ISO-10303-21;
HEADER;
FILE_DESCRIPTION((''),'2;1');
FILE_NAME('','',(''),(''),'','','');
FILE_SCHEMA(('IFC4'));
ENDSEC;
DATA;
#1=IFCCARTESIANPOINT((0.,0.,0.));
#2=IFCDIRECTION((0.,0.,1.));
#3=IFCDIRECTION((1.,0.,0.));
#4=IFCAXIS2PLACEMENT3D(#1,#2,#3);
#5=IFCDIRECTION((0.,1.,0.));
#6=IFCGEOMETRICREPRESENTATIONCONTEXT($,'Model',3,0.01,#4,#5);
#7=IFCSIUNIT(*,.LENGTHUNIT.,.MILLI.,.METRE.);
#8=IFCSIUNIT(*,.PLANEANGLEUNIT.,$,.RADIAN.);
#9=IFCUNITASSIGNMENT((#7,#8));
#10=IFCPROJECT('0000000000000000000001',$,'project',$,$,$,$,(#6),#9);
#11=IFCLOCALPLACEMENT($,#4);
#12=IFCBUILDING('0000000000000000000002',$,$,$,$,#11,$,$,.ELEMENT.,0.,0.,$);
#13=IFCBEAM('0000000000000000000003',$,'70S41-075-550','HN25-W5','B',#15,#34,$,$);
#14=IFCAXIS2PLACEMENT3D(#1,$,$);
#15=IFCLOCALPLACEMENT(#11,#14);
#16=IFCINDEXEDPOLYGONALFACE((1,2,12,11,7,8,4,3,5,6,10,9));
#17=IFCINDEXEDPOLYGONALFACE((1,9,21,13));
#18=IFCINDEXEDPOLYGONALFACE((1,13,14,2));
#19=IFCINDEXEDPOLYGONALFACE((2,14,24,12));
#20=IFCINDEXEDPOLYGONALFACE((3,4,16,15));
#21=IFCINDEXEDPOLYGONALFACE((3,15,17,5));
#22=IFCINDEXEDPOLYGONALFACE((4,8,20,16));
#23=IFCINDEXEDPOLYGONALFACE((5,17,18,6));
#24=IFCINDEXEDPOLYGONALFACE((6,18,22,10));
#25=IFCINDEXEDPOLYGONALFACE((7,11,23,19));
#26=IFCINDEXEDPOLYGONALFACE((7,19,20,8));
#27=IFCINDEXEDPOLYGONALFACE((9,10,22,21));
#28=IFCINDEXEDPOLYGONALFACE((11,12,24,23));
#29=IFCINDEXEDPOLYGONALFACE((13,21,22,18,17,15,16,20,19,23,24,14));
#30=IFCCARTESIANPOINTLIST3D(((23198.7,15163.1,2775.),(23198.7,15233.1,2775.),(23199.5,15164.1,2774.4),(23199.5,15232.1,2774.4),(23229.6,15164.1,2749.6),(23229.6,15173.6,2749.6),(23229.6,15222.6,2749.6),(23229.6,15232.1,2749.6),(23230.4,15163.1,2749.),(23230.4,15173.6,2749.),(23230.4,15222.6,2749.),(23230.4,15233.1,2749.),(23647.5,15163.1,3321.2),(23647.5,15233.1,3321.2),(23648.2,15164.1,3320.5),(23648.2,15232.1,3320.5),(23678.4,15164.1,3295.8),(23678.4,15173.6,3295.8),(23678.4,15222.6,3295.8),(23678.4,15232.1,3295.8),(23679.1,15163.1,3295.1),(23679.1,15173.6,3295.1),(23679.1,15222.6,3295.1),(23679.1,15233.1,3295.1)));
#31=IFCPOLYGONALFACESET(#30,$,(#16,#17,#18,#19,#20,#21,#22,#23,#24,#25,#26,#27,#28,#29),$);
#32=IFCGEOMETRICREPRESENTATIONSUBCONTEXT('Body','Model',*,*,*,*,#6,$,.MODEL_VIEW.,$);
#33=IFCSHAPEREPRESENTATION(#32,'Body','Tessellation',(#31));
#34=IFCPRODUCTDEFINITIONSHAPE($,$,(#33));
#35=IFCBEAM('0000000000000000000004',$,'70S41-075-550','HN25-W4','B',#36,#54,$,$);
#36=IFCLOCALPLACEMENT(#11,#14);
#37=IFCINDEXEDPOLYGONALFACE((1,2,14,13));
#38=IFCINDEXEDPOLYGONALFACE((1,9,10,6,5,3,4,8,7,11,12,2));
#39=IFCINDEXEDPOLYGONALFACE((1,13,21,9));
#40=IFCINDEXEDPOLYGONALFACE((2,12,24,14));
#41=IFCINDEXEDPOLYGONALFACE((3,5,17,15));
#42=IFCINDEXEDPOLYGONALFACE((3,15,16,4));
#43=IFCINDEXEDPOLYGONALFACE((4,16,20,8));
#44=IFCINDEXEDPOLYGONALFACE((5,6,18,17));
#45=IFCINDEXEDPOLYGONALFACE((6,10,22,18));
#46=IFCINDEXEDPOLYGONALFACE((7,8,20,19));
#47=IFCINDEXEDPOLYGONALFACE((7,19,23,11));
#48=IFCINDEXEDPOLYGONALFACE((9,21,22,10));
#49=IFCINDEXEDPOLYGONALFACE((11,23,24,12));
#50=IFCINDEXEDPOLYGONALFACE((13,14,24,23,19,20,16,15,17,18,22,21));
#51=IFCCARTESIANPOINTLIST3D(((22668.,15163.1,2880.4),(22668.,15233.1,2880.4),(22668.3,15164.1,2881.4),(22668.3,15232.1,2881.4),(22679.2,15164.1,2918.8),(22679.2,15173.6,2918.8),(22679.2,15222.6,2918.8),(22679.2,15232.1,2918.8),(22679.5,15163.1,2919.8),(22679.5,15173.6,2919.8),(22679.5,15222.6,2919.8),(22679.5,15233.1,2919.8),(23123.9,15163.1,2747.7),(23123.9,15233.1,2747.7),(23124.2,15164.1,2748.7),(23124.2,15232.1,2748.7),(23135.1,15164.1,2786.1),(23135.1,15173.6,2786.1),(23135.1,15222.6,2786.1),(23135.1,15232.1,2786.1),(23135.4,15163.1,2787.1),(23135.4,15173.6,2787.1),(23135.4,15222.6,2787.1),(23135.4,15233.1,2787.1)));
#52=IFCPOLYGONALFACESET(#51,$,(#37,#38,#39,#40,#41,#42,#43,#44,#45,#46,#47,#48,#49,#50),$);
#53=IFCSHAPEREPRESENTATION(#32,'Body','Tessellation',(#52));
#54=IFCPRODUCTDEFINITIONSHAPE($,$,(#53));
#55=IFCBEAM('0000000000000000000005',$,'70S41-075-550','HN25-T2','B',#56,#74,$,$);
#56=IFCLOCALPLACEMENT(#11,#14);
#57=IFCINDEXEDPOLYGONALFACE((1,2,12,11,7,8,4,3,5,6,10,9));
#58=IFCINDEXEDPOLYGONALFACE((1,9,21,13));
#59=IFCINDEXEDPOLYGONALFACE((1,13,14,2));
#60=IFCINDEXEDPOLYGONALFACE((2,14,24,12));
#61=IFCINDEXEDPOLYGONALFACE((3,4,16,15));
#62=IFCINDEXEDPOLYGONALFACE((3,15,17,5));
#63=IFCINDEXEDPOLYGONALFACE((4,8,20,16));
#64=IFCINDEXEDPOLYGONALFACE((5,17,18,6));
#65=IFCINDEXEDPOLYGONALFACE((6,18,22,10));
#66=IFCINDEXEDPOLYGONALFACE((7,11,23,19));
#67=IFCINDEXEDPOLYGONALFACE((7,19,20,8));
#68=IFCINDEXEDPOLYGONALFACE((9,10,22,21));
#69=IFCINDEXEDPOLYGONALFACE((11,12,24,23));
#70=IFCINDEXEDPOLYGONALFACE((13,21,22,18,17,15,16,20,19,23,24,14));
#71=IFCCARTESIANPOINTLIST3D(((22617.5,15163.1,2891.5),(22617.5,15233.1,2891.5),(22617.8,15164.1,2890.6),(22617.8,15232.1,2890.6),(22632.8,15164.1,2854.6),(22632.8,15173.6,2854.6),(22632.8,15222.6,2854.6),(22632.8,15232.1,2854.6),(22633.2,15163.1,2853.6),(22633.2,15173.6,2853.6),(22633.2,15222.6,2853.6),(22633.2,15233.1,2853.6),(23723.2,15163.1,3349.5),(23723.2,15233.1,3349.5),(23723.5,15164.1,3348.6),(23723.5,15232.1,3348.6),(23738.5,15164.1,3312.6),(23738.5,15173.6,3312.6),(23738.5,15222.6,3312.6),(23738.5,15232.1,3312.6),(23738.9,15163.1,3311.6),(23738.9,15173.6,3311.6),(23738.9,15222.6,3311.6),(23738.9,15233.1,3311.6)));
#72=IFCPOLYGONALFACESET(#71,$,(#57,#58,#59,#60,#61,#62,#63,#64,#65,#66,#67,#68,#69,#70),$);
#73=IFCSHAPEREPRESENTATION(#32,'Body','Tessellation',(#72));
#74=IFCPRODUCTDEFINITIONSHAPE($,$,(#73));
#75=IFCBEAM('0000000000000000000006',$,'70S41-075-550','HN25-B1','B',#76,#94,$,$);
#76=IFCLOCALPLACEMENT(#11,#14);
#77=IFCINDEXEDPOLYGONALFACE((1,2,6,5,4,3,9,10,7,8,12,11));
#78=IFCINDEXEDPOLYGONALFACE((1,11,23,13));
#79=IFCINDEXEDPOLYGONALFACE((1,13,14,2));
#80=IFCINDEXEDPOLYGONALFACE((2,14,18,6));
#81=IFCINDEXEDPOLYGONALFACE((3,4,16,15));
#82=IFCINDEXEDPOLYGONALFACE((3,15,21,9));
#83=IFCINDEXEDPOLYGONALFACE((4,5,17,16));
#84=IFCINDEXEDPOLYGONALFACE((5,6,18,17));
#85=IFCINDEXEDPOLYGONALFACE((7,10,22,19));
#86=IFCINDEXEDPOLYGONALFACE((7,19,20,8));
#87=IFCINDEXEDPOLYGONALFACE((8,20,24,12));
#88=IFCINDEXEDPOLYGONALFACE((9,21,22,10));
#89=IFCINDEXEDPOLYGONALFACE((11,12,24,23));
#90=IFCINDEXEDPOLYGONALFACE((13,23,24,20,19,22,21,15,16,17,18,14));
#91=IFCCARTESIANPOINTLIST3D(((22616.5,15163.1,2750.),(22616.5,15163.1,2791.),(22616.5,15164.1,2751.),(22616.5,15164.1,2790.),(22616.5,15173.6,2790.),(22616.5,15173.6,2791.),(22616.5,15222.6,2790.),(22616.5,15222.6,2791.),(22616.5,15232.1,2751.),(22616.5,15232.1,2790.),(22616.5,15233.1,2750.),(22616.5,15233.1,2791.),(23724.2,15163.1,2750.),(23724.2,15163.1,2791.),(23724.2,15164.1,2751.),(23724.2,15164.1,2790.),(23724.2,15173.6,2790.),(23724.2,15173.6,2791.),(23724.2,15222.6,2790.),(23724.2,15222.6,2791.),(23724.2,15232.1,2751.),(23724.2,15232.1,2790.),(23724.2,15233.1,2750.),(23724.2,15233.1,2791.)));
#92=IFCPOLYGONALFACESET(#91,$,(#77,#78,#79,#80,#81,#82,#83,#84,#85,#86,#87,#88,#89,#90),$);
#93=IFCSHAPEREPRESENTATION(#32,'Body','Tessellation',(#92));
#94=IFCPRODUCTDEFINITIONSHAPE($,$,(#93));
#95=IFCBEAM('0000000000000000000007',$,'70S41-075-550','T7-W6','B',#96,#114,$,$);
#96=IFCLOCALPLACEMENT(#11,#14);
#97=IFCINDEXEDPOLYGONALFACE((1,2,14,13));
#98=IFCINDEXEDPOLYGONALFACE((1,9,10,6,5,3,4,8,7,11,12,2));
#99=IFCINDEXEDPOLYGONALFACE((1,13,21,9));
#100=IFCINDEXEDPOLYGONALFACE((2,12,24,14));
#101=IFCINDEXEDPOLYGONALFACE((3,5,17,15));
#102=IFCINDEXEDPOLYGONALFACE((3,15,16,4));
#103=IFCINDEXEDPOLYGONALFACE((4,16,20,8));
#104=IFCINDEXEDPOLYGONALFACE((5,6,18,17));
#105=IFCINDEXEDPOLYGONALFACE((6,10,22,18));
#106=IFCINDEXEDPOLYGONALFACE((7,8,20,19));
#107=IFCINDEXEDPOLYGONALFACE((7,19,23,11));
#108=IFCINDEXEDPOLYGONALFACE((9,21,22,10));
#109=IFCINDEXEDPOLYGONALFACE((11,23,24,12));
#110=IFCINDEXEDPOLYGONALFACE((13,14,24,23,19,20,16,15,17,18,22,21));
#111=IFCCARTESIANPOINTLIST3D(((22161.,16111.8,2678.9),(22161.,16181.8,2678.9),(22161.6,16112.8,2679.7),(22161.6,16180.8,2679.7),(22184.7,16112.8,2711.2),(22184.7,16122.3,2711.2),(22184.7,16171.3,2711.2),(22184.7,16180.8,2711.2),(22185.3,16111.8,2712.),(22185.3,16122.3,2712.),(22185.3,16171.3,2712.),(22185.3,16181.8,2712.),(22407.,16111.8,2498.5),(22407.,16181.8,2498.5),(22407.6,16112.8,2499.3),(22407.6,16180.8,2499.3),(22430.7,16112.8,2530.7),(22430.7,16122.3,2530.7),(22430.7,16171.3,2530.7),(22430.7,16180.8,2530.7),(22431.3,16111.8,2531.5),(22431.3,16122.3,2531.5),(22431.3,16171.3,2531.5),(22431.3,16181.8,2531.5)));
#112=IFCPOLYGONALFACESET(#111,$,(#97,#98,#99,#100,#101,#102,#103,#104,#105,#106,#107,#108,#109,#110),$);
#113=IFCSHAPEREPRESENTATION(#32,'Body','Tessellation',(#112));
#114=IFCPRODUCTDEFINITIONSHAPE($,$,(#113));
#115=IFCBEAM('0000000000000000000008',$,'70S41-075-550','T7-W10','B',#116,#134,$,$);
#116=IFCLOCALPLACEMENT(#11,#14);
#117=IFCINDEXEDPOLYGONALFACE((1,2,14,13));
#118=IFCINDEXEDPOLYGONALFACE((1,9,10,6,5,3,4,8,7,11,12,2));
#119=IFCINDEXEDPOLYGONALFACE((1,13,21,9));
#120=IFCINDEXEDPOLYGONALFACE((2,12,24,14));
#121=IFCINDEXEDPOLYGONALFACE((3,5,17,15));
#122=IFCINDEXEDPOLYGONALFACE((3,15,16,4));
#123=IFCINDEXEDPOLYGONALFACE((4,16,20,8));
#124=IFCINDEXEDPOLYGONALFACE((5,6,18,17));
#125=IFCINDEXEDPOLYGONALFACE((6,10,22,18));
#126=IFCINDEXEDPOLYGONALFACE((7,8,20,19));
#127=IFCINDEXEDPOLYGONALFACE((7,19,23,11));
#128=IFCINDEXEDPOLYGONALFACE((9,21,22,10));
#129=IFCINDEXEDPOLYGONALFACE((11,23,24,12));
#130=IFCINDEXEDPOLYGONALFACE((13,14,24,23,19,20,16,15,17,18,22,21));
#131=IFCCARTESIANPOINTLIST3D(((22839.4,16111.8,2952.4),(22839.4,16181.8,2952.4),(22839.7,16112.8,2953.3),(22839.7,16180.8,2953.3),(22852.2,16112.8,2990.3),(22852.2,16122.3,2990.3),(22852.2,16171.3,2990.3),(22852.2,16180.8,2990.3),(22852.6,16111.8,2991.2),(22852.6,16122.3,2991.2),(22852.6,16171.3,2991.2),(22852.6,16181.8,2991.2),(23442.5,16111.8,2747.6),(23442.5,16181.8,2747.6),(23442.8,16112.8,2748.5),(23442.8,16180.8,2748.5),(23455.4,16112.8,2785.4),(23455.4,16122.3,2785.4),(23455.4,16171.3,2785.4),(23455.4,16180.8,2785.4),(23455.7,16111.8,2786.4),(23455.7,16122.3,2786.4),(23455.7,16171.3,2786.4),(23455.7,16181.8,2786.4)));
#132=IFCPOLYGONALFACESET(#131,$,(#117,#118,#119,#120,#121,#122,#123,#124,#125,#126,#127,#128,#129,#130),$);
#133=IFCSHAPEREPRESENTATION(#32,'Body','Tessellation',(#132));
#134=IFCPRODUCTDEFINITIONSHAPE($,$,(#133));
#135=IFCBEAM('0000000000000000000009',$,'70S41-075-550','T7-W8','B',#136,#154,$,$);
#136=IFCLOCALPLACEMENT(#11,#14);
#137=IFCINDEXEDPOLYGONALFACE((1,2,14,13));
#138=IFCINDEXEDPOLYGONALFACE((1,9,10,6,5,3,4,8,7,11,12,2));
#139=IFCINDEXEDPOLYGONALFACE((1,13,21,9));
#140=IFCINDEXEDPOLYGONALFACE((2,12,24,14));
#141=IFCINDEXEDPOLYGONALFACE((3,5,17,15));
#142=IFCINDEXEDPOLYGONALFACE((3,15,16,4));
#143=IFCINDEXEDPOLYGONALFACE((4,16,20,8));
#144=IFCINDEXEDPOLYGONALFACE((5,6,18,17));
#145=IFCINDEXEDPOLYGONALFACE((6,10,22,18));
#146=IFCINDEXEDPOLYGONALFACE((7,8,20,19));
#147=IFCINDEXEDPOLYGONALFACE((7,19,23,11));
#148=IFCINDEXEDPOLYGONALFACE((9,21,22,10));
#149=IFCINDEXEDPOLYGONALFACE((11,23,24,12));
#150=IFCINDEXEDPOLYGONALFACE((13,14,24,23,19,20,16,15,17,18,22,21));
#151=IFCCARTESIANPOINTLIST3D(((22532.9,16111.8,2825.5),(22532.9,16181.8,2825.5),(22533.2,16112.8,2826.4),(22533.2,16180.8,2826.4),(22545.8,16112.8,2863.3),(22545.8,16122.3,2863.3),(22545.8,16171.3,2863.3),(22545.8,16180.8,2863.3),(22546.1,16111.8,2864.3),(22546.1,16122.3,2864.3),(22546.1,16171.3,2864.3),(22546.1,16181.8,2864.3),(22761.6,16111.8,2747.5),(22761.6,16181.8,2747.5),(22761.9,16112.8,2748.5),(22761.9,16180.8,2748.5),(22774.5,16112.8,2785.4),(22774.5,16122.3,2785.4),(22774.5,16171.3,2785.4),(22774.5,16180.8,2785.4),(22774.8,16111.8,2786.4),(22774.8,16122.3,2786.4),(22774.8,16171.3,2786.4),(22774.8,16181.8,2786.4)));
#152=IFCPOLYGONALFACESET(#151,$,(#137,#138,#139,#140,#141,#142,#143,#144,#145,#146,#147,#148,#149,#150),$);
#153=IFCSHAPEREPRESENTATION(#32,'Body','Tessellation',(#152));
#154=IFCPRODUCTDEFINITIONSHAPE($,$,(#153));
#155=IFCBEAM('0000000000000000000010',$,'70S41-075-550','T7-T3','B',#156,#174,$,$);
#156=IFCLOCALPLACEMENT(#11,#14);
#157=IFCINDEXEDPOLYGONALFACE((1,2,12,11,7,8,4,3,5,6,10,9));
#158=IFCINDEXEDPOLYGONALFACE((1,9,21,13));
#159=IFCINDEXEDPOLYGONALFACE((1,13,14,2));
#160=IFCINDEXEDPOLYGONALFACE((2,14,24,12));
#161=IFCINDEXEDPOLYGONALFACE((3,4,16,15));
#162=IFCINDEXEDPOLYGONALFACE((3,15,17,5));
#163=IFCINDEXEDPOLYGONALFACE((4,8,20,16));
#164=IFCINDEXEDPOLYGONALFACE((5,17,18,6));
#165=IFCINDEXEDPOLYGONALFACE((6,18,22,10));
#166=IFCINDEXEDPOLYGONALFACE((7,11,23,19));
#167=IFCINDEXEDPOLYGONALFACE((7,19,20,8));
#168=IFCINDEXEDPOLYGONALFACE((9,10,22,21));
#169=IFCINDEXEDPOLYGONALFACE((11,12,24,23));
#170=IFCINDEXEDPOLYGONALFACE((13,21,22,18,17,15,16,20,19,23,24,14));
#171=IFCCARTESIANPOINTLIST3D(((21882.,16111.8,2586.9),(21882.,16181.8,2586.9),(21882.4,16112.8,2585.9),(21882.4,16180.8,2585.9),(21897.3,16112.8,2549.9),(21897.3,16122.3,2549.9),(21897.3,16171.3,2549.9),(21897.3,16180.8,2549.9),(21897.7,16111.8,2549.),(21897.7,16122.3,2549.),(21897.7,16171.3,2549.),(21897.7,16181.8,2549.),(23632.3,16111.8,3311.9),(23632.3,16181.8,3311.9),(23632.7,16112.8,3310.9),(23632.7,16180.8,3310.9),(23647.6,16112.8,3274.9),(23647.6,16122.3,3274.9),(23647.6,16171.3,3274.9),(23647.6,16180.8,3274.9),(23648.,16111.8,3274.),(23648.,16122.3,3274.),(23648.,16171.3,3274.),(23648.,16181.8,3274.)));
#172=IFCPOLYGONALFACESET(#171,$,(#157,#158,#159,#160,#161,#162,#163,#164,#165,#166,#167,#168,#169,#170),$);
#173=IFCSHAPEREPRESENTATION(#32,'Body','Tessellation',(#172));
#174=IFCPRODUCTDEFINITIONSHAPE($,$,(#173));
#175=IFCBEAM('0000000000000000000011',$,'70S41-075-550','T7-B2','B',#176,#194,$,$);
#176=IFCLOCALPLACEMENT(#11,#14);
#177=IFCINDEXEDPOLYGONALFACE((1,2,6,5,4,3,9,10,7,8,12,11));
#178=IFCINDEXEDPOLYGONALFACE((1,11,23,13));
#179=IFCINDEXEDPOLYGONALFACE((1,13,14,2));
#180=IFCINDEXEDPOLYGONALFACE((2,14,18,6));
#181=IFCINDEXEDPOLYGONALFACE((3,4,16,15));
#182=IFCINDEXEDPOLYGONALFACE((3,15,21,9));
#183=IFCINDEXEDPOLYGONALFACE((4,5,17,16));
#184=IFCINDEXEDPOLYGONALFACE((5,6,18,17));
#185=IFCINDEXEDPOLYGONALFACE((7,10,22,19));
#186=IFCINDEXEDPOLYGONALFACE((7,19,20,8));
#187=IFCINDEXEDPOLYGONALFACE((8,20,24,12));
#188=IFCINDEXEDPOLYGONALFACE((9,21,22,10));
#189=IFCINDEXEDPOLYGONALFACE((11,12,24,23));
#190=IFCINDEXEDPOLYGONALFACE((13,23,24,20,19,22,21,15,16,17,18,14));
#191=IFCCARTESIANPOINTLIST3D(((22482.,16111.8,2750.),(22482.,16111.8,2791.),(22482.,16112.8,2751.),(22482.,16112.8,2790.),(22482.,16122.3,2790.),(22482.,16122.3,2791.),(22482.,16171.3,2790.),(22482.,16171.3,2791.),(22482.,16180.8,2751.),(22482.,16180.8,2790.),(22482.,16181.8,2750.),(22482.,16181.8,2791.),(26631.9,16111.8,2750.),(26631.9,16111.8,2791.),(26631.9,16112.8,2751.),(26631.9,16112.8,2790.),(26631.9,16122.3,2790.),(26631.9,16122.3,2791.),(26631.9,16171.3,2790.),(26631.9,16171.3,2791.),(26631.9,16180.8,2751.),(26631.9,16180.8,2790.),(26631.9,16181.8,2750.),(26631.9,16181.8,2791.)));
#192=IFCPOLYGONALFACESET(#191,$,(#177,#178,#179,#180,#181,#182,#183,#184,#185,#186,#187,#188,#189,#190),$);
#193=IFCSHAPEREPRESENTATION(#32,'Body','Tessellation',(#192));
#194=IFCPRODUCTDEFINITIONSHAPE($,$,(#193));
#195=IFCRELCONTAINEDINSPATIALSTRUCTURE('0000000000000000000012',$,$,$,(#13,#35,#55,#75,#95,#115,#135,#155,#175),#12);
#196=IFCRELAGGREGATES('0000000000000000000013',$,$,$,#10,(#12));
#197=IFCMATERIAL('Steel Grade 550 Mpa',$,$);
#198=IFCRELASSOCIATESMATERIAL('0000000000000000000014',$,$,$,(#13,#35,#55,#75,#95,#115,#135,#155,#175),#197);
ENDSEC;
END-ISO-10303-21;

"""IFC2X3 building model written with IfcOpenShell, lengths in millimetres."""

from ifc_helpers import new_model, si_unit, direction, frame, origin, origin_with_axes, origin_2d_with_axis, place, context, subcontext, project, spatial, c_section, extrude, source, transform, mapped, material, element, save


model = new_model("IFC2X3")

# Units and contexts
model_context = context("Model", 3, precision=0.01, world=origin_with_axes(), true_north=direction((0.0, 1.0, 0.0)))
body_context = subcontext(model_context, "Body", "Model", "MODEL_VIEW")
ifc_project = project(units=[si_unit("LENGTHUNIT", "METRE", prefix="MILLI"), si_unit("PLANEANGLEUNIT", "RADIAN")], contexts=[model_context])

# Building
building_placement = place(None, origin_with_axes())
building = spatial("IfcBuilding", under=ifc_project, at=building_placement, CompositionType="ELEMENT", ElevationOfRefHeight=0.0, ElevationOfTerrain=0.0)

# Shared definitions
ifc_material = material(Name="Steel Grade 550 Mpa")

# Beams
shared_shape_1 = source(origin(), body_context, "Body", "SweptSolid", [
    extrude(c_section(Depth=70.0, Width=41.0, WallThickness=1.0, Girth=10.5, at=origin_2d_with_axis()), origin_with_axes(), (0.0, 0.0, 1.0), 706.8),
])
beam_1_placement = place(None, frame((23663.3, 15198.1, 3308.1), z_axis=(-0.634825, 0.0, -0.772656), x_axis=(0.772656, 0.0, -0.634825)))
element("IfcBeam", 1, at=beam_1_placement, inside=building, material=ifc_material, Name="70S41-075-550", Description="HN25-W5", ObjectType="B", context=body_context, shape_type="MappedRepresentation", body=[
    mapped(shared_shape_1, transform((0.0, 0.0, 0.0), scale=1.0)),
])
shared_shape_2 = source(origin(), body_context, "Body", "SweptSolid", [
    extrude(c_section(Depth=70.0, Width=41.0, WallThickness=1.0, Girth=10.5, at=origin_2d_with_axis()), origin_with_axes(), (0.0, 0.0, 1.0), 474.8),
])
beam_2_placement = place(None, frame((22673.7, 15198.1, 2900.1), z_axis=(0.960164, 0.0, -0.279439), x_axis=(0.279439, 0.0, 0.960164)))
element("IfcBeam", 2, at=beam_2_placement, inside=building, material=ifc_material, Name="70S41-075-550", Description="HN25-W4", ObjectType="B", context=body_context, shape_type="MappedRepresentation", body=[
    mapped(shared_shape_2, transform((0.0, 0.0, 0.0), scale=1.0)),
])
shared_shape_3 = source(origin(), body_context, "Body", "SweptSolid", [
    extrude(c_section(Depth=70.0, Width=41.0, WallThickness=1.0, Girth=10.5, at=origin_2d_with_axis()), origin_with_axes(), (0.0, 0.0, 1.0), 1196.8),
])
beam_3_placement = place(None, frame((23731.0, 15198.1, 3330.6), z_axis=(-0.92388, 0.0, -0.382683), x_axis=(0.382683, 0.0, -0.92388)))
element("IfcBeam", 3, at=beam_3_placement, inside=building, material=ifc_material, Name="70S41-075-550", Description="HN25-T2", ObjectType="B", context=body_context, shape_type="MappedRepresentation", body=[
    mapped(shared_shape_3, transform((0.0, 0.0, 0.0), scale=1.0)),
])
shared_shape_4 = source(origin(), body_context, "Body", "SweptSolid", [
    extrude(c_section(Depth=70.0, Width=41.0, WallThickness=1.0, Girth=10.5, at=origin_2d_with_axis()), origin_with_axes(), (0.0, 0.0, 1.0), 1107.7),
])
beam_4_placement = place(None, frame((22616.5, 15198.1, 2770.5), z_axis=(1.0, 0.0, 0.0), x_axis=(0.0, 0.0, 1.0)))
element("IfcBeam", 4, at=beam_4_placement, inside=building, material=ifc_material, Name="70S41-075-550", Description="HN25-B1", ObjectType="B", context=body_context, shape_type="MappedRepresentation", body=[
    mapped(shared_shape_4, transform((0.0, 0.0, 0.0), scale=1.0)),
])
shared_shape_5 = source(origin(), body_context, "Body", "SweptSolid", [
    extrude(c_section(Depth=70.0, Width=41.0, WallThickness=1.0, Girth=10.5, at=origin_2d_with_axis()), origin_with_axes(), (0.0, 0.0, 1.0), 305.1),
])
beam_5_placement = place(None, frame((22173.2, 16146.8, 2695.5), z_axis=(0.806298, 0.0, -0.59151), x_axis=(0.59151, 0.0, 0.806298)))
element("IfcBeam", 5, at=beam_5_placement, inside=building, material=ifc_material, Name="70S41-075-550", Description="T7-W6", ObjectType="B", context=body_context, shape_type="MappedRepresentation", body=[
    mapped(shared_shape_5, transform((0.0, 0.0, 0.0), scale=1.0)),
])
shared_shape_6 = source(origin(), body_context, "Body", "SweptSolid", [
    extrude(c_section(Depth=70.0, Width=41.0, WallThickness=1.0, Girth=10.5, at=origin_2d_with_axis()), origin_with_axes(), (0.0, 0.0, 1.0), 637.0),
])
beam_6_placement = place(None, frame((22846.0, 16146.8, 2971.8), z_axis=(0.946875, 0.0, -0.321601), x_axis=(0.321601, 0.0, 0.946875)))
element("IfcBeam", 6, at=beam_6_placement, inside=building, material=ifc_material, Name="70S41-075-550", Description="T7-W10", ObjectType="B", context=body_context, shape_type="MappedRepresentation", body=[
    mapped(shared_shape_6, transform((0.0, 0.0, 0.0), scale=1.0)),
])
shared_shape_7 = source(origin(), body_context, "Body", "SweptSolid", [
    extrude(c_section(Depth=70.0, Width=41.0, WallThickness=1.0, Girth=10.5, at=origin_2d_with_axis()), origin_with_axes(), (0.0, 0.0, 1.0), 241.6),
])
beam_7_placement = place(None, frame((22539.5, 16146.8, 2844.9), z_axis=(0.946599, 0.0, -0.322414), x_axis=(0.322414, 0.0, 0.946599)))
element("IfcBeam", 7, at=beam_7_placement, inside=building, material=ifc_material, Name="70S41-075-550", Description="T7-W8", ObjectType="B", context=body_context, shape_type="MappedRepresentation", body=[
    mapped(shared_shape_7, transform((0.0, 0.0, 0.0), scale=1.0)),
])
shared_shape_8 = source(origin(), body_context, "Body", "SweptSolid", [
    extrude(c_section(Depth=70.0, Width=41.0, WallThickness=1.0, Girth=10.5, at=origin_2d_with_axis()), origin_with_axes(), (0.0, 0.0, 1.0), 1894.5),
])
beam_8_placement = place(None, frame((23640.2, 16146.8, 3292.9), z_axis=(-0.92388, 0.0, -0.382683), x_axis=(0.382683, 0.0, -0.92388)))
element("IfcBeam", 8, at=beam_8_placement, inside=building, material=ifc_material, Name="70S41-075-550", Description="T7-T3", ObjectType="B", context=body_context, shape_type="MappedRepresentation", body=[
    mapped(shared_shape_8, transform((0.0, 0.0, 0.0), scale=1.0)),
])
shared_shape_9 = source(origin(), body_context, "Body", "SweptSolid", [
    extrude(c_section(Depth=70.0, Width=41.0, WallThickness=1.0, Girth=10.5, at=origin_2d_with_axis()), origin_with_axes(), (0.0, 0.0, 1.0), 4149.9),
])
beam_9_placement = place(None, frame((22482.0, 16146.8, 2770.5), z_axis=(1.0, 0.0, 0.0), x_axis=(0.0, 0.0, 1.0)))
element("IfcBeam", 9, at=beam_9_placement, inside=building, material=ifc_material, Name="70S41-075-550", Description="T7-B2", ObjectType="B", context=body_context, shape_type="MappedRepresentation", body=[
    mapped(shared_shape_9, transform((0.0, 0.0, 0.0), scale=1.0)),
])

save(model, "model.ifc")
